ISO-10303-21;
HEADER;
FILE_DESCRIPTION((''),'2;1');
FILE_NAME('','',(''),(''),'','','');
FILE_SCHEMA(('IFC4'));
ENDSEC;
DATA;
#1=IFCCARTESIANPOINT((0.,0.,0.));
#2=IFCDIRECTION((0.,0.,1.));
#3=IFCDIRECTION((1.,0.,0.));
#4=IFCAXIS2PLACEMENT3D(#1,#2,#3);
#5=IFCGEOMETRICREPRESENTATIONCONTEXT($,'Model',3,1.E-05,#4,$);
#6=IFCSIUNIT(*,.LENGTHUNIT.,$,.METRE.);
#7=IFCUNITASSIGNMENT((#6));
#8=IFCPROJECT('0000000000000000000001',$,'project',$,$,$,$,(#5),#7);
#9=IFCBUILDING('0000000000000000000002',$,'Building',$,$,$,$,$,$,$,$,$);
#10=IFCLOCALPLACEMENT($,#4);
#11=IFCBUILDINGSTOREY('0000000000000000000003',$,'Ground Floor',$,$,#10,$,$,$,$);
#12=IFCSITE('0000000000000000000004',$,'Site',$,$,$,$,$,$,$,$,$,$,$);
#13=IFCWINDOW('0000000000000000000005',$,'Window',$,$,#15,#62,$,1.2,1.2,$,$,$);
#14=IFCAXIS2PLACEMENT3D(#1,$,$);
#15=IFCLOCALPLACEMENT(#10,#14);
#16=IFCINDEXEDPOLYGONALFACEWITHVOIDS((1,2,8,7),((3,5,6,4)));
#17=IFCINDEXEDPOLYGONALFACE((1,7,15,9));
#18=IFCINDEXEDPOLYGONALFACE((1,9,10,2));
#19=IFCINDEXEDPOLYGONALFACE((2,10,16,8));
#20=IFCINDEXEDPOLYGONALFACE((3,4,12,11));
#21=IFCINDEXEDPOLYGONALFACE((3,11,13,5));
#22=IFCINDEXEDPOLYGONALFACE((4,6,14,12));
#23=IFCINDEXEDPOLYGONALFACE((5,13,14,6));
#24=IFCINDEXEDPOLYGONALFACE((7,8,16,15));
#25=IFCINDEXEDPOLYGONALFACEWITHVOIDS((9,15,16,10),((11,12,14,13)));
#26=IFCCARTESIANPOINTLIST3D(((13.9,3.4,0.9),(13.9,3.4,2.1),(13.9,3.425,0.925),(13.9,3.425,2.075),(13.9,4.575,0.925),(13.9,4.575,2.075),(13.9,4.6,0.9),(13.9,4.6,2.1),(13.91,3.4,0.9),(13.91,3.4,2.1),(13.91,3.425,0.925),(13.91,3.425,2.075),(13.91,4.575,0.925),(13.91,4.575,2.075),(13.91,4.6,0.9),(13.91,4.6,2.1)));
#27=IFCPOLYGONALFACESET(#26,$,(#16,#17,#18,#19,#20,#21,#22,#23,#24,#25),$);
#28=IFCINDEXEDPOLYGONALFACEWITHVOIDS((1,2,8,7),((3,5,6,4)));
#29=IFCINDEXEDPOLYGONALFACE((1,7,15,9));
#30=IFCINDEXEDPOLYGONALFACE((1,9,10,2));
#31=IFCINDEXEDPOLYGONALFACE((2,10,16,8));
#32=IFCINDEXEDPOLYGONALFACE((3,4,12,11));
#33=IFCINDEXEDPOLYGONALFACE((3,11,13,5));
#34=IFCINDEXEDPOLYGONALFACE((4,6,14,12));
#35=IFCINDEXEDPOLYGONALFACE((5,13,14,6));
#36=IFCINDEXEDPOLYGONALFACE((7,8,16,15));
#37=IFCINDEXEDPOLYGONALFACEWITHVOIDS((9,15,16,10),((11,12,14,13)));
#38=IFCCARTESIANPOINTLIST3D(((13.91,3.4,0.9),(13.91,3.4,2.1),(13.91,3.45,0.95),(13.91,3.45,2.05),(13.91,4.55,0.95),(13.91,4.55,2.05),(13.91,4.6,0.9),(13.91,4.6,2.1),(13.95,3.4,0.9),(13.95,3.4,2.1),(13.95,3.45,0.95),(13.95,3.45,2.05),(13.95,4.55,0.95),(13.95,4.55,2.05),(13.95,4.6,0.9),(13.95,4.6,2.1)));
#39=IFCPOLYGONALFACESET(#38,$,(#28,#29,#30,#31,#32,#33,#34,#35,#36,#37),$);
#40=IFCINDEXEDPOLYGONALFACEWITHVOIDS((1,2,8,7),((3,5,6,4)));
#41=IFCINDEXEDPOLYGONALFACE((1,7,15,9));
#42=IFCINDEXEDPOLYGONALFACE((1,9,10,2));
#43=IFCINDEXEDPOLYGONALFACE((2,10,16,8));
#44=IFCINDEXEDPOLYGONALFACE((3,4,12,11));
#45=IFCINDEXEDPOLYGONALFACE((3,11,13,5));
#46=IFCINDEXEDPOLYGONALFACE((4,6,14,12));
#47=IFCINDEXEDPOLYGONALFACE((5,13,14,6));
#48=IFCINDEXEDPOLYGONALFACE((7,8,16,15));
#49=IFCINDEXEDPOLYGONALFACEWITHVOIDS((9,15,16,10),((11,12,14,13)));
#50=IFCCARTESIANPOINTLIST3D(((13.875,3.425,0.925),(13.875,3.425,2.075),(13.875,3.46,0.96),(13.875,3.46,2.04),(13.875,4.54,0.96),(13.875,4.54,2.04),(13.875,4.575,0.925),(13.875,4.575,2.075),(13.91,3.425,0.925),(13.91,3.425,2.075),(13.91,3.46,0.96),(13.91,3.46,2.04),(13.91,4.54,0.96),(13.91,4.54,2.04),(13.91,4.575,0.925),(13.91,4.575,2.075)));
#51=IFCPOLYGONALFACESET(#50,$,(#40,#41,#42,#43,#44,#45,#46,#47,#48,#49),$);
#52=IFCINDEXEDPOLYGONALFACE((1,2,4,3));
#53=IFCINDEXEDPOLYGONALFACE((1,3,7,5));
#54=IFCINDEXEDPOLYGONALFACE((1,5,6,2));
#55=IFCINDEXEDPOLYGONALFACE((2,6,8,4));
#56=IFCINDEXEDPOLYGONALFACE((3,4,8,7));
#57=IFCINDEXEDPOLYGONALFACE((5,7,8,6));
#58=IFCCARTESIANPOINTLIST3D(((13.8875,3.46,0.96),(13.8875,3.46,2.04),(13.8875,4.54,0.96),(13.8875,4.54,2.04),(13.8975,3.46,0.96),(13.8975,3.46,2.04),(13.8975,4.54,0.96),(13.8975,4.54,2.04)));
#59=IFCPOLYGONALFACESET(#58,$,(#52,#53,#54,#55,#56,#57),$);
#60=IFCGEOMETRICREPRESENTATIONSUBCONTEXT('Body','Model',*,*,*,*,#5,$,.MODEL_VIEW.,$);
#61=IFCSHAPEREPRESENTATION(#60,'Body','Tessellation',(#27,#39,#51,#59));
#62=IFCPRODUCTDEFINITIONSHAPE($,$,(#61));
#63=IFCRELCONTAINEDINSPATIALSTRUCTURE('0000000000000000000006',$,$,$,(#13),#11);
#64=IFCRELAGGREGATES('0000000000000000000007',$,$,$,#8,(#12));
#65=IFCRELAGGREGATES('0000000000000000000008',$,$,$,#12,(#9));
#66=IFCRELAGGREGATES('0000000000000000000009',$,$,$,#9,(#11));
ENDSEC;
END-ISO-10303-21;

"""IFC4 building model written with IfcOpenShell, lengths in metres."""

from ifc_helpers import new_model, si_unit, frame, origin_with_axes, place, context, subcontext, project, spatial, line, indexed_curve, outline, extrude, element, save


model = new_model("IFC4")

# Units and contexts
model_context = context("Model", 3, precision=1e-05, world=origin_with_axes())
body_context = subcontext(model_context, "Body", "Model", "MODEL_VIEW")
ifc_project = project(units=[si_unit("LENGTHUNIT", "METRE")], contexts=[model_context])

# Site, building, storey
site = spatial("IfcSite", under=ifc_project, Name="Site")
building = spatial("IfcBuilding", under=site, Name="Building")
storey_placement = place(None, origin_with_axes())
storey = spatial("IfcBuildingStorey", under=building, at=storey_placement, Name="Ground Floor")

# Window
for number, where, z_axis, x_axis, name in (
    (1, (14.0, 3.4, 0.9), (0.0, 0.0, 1.0), (0.0, 1.0, 0.0), "Window"),
):
    element("IfcWindow", number, at=place(storey_placement, frame(where, z_axis=z_axis, x_axis=x_axis)), inside=storey, Name=name, OverallHeight=1.2, OverallWidth=1.2, context=body_context, shape_type="SweptSolid", body=[
        extrude(outline(indexed_curve([(0.0, 0.0), (1.2, 0.0), (1.2, 1.2), (0.0, 1.2)], segments=[line(1, 2, 3, 4, 1)]), holes=[indexed_curve([(0.025, 0.025), (1.175, 0.025), (1.175, 1.175), (0.025, 1.175)], segments=[line(1, 2, 3, 4, 1)])]), frame((0.0, 0.09, 0.0), z_axis=(0.0, -1.0, 0.0), x_axis=(1.0, 0.0, 0.0)), (0.0, 0.0, -1.0), 0.01),
        extrude(outline(indexed_curve([(0.0, 0.0), (1.2, 0.0), (1.2, 1.2), (0.0, 1.2)], segments=[line(1, 2, 3, 4, 1)]), holes=[indexed_curve([(0.05, 0.05), (1.15, 0.05), (1.15, 1.15), (0.05, 1.15)], segments=[line(1, 2, 3, 4, 1)])]), frame((0.0, 0.05, 0.0), z_axis=(0.0, -1.0, 0.0), x_axis=(1.0, 0.0, 0.0)), (0.0, 0.0, -1.0), 0.04),
        extrude(outline(indexed_curve([(0.0, 0.0), (1.15, 0.0), (1.15, 1.15), (0.0, 1.15)], segments=[line(1, 2, 3, 4, 1)]), holes=[indexed_curve([(0.035, 0.035), (1.115, 0.035), (1.115, 1.115), (0.035, 1.115)], segments=[line(1, 2, 3, 4, 1)])]), frame((0.025, 0.09, 0.025), z_axis=(0.0, -1.0, 0.0), x_axis=(1.0, 0.0, 0.0)), (0.0, 0.0, -1.0), 0.035),
        extrude(outline(indexed_curve([(0.035, 0.035), (1.115, 0.035), (1.115, 1.115), (0.035, 1.115)], segments=[line(1, 2, 3, 4, 1)])), frame((0.025, 0.1025, 0.025), z_axis=(0.0, -1.0, 0.0), x_axis=(1.0, 0.0, 0.0)), (0.0, 0.0, -1.0), 0.01),
    ])

save(model, "model.ifc")
